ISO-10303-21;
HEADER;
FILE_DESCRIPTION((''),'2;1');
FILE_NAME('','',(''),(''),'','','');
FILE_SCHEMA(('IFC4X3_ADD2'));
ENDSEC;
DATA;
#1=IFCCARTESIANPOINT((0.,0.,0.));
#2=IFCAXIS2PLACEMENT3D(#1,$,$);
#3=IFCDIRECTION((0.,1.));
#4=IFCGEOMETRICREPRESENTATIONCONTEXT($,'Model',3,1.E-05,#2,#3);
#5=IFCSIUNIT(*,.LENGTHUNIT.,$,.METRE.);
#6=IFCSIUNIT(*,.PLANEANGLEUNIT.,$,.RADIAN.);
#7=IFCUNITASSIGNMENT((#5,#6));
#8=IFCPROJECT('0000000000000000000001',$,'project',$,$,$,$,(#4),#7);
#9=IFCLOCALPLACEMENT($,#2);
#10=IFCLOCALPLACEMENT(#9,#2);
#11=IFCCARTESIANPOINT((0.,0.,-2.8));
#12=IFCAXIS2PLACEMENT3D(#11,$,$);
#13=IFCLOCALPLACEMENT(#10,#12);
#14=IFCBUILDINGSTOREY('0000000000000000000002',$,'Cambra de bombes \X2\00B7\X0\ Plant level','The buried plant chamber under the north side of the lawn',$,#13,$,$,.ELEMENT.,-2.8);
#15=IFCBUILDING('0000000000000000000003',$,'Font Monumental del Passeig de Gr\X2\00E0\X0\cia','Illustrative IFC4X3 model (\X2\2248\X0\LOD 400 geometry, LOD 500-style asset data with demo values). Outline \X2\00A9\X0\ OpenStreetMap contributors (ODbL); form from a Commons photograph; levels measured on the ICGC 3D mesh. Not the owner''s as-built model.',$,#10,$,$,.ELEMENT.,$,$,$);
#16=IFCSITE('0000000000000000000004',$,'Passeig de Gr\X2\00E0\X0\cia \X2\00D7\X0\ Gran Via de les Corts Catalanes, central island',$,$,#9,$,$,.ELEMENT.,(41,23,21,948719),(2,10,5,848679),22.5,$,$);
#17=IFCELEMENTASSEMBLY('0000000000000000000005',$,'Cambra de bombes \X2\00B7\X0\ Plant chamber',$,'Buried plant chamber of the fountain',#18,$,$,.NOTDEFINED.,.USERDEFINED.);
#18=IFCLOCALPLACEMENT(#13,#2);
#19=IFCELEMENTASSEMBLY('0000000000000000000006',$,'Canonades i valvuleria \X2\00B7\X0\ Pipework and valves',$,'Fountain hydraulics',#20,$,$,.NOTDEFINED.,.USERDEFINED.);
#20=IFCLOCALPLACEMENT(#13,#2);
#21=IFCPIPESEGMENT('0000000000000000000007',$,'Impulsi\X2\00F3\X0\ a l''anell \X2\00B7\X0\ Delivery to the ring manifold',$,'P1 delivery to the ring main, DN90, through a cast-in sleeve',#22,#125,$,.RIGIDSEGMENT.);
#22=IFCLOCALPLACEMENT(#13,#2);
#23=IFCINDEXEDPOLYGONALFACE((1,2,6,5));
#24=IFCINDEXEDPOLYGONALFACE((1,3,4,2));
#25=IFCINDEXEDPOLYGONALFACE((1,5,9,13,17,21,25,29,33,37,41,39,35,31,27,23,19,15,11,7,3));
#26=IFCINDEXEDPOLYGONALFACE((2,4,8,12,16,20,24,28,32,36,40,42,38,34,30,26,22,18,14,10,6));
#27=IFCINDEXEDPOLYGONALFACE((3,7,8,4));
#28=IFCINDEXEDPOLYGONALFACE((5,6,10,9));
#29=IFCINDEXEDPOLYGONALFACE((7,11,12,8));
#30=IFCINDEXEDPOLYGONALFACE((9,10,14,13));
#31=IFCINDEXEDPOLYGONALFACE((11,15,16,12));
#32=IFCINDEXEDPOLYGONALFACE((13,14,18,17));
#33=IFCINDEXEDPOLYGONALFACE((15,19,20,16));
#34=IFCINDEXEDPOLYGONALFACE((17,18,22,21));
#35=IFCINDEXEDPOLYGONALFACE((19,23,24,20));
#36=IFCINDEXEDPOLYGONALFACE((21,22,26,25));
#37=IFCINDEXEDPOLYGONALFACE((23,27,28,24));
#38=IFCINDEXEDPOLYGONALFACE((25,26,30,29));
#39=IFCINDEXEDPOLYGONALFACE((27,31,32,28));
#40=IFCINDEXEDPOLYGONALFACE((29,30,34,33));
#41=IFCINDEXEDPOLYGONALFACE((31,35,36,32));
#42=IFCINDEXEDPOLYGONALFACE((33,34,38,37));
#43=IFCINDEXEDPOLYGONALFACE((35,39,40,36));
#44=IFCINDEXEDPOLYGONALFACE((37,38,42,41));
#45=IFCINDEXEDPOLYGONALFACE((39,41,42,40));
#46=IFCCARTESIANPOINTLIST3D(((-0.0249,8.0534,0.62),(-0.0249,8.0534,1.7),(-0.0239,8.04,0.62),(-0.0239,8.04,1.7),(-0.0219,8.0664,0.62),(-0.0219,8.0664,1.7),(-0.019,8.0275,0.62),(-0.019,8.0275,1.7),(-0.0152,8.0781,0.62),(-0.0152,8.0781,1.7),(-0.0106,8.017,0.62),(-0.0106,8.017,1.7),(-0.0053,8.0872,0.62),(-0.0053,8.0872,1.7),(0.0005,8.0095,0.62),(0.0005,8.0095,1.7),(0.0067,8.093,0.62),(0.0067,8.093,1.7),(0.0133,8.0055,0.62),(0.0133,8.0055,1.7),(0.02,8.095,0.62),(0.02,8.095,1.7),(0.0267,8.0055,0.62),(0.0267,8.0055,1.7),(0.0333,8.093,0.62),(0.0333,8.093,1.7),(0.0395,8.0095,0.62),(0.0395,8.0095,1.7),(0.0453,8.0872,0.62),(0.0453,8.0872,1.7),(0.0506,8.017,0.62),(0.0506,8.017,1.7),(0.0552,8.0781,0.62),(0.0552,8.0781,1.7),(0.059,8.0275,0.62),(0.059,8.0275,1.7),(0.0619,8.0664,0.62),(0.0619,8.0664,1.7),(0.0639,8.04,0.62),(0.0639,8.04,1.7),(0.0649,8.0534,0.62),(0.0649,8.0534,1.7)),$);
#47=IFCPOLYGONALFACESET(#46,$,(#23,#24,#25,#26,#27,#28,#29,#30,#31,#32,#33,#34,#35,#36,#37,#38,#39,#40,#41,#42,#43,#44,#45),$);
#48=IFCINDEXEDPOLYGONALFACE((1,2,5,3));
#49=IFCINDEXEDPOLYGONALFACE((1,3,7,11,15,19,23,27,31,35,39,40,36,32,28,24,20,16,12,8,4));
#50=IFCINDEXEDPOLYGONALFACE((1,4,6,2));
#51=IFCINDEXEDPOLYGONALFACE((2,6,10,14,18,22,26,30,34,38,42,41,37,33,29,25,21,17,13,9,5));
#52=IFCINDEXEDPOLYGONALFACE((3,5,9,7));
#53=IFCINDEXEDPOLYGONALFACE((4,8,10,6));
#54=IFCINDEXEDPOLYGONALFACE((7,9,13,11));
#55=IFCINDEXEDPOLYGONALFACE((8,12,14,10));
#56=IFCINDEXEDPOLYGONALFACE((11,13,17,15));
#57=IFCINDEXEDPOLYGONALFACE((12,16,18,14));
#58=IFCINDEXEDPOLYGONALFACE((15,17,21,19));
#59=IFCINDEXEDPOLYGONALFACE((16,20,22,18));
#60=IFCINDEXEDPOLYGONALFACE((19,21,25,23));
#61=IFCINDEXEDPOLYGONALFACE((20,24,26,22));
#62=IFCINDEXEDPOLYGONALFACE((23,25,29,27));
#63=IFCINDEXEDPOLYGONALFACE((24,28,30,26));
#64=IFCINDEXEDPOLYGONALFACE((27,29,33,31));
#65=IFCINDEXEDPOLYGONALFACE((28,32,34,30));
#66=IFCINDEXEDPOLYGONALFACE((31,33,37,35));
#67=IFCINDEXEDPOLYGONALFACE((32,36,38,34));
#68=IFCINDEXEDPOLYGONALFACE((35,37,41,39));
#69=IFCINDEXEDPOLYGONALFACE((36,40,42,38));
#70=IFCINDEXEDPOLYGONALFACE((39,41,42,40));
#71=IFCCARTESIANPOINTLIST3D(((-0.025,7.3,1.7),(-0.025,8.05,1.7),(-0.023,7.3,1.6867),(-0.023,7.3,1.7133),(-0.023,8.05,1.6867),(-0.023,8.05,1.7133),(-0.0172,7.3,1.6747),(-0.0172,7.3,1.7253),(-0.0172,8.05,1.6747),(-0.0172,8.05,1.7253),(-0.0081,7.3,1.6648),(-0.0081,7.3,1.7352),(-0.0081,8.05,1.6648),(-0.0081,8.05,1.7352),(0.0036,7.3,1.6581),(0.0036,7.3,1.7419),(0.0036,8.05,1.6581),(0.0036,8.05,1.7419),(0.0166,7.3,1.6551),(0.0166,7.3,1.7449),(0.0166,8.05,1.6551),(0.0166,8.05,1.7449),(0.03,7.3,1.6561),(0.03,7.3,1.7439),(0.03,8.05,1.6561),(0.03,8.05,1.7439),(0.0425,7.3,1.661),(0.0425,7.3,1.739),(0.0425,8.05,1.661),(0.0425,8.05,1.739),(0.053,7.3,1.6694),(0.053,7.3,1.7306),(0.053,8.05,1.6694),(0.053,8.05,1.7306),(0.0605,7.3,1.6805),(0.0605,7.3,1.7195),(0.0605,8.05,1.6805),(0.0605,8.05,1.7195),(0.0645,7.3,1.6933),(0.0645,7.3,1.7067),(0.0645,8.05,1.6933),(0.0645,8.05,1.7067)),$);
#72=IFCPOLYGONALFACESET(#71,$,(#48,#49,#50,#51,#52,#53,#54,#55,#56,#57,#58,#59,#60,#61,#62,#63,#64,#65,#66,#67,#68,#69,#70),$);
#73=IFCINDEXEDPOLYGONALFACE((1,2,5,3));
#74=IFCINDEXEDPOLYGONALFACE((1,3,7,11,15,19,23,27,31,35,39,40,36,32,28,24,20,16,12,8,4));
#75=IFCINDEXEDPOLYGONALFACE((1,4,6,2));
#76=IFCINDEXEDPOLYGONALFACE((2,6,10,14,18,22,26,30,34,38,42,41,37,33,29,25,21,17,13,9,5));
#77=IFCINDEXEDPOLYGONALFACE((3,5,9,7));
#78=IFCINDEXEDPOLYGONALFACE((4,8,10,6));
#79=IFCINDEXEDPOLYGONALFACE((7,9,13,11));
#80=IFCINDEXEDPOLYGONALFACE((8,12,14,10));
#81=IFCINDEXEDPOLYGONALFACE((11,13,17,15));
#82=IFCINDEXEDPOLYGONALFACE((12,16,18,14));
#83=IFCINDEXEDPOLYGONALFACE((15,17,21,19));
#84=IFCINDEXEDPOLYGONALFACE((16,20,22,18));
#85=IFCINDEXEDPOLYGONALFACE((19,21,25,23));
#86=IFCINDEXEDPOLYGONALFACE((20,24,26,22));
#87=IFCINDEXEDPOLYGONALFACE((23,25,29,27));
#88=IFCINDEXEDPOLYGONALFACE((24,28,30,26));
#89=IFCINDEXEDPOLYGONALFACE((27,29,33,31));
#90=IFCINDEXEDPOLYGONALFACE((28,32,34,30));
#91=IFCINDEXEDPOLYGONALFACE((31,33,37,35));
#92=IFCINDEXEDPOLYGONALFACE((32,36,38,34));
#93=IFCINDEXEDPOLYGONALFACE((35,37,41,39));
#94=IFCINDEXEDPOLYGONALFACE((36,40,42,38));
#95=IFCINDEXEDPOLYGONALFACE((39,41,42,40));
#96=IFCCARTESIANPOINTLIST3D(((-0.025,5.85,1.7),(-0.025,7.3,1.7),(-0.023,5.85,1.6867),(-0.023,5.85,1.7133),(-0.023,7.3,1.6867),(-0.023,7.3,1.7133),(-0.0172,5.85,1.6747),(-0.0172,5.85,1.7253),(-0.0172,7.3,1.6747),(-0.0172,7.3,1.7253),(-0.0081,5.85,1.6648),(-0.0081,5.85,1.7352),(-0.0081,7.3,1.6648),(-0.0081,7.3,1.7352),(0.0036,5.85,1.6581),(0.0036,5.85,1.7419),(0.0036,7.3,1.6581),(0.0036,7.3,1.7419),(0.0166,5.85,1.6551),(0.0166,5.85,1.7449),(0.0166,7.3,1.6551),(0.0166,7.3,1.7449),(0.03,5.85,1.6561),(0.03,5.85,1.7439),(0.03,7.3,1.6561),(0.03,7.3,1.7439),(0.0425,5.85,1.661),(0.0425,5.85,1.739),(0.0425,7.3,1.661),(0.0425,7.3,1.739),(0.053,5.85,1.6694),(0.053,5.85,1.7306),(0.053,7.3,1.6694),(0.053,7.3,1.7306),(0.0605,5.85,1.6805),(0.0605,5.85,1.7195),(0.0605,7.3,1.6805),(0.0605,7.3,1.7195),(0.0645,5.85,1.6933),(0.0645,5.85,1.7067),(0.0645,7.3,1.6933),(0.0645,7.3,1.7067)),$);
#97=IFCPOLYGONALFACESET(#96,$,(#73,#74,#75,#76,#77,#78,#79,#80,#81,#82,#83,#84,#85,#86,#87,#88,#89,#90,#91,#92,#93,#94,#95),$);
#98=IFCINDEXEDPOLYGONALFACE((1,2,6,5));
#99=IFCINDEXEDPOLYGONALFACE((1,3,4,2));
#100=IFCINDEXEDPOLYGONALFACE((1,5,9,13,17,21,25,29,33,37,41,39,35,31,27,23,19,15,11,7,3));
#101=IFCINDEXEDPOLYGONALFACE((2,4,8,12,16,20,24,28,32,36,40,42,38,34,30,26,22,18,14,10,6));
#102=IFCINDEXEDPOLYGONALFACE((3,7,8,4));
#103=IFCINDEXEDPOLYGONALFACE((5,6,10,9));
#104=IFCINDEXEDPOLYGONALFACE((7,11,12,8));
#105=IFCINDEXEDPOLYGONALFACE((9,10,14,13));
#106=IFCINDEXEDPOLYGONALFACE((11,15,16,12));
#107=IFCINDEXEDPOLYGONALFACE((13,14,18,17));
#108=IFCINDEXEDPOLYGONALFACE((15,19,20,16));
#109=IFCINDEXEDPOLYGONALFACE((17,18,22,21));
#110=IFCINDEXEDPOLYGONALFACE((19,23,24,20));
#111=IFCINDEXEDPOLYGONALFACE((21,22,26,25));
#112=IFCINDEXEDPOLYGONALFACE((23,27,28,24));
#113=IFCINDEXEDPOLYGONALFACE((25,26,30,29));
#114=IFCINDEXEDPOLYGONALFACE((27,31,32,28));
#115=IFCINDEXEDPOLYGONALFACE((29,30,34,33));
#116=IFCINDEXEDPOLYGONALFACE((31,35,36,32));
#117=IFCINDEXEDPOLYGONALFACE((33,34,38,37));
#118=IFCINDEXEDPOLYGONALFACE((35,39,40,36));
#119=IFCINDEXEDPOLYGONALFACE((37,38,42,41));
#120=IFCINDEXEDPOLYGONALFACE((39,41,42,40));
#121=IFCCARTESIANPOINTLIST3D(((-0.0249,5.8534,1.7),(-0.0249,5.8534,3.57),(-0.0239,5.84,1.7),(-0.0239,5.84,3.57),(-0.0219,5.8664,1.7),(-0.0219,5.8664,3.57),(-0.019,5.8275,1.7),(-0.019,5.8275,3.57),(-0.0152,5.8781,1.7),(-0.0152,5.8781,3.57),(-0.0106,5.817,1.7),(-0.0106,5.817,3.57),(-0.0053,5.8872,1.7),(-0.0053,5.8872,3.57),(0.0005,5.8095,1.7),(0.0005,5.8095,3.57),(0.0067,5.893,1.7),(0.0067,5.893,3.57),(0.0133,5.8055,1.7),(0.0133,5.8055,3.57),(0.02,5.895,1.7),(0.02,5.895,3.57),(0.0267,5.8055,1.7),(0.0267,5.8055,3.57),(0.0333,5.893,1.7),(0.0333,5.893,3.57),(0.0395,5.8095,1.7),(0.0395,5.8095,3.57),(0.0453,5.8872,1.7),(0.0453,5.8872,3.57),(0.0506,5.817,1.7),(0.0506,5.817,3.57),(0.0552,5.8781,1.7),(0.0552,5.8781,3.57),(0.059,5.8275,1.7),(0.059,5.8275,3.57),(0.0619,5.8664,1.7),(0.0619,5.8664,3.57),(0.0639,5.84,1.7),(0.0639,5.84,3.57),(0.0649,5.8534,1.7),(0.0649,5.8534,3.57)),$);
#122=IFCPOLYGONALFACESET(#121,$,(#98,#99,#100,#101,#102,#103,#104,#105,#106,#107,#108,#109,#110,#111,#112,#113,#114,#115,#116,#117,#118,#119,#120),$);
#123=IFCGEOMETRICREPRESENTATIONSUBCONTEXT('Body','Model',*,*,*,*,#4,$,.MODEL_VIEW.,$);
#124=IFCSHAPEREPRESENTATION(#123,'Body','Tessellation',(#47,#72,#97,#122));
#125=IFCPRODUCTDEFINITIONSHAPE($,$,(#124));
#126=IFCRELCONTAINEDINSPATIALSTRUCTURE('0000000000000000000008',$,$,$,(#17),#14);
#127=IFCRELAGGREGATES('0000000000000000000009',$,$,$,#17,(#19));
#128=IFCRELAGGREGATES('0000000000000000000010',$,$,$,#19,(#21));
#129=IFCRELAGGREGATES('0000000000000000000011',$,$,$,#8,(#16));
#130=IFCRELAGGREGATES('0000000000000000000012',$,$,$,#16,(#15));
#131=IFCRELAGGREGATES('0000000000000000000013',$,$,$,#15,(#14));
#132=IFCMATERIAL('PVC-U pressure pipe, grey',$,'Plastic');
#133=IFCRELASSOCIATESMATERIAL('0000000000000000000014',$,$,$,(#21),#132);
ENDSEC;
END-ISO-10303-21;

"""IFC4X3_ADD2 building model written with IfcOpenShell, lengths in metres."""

from ifc_helpers import new_model, si_unit, direction, frame, origin, origin_2d_with_axis, place, context, subcontext, project, spatial, circle, extrude, material, element, aggregate, save


model = new_model("IFC4X3_ADD2")

# Units and contexts
model_context = context("Model", 3, precision=1e-05, world=origin(), true_north=direction((0.0, 1.0)))
body_context = subcontext(model_context, "Body", "Model", "MODEL_VIEW")
ifc_project = project(units=[si_unit("LENGTHUNIT", "METRE"), si_unit("PLANEANGLEUNIT", "RADIAN")], contexts=[model_context])

# Site, building, storey
site_placement = place(None, origin())
site = spatial("IfcSite", under=ifc_project, at=site_placement, Name="Passeig de Gràcia × Gran Via de les Corts Catalanes, central island", CompositionType="ELEMENT", RefLatitude=(41, 23, 21, 948719), RefLongitude=(2, 10, 5, 848679), RefElevation=22.5)
building_placement = place(site_placement, origin())
building = spatial("IfcBuilding", under=site, at=building_placement, Name="Font Monumental del Passeig de Gràcia", Description="Illustrative IFC4X3 model (≈LOD 400 geometry, LOD 500-style asset data with demo values). Outline © OpenStreetMap contributors (ODbL); form from a Commons photograph; levels measured on the ICGC 3D mesh. Not the owner's as-built model.", CompositionType="ELEMENT")
storey_placement = place(building_placement, frame((0.0, 0.0, -2.8)))
storey = spatial("IfcBuildingStorey", under=building, at=storey_placement, Name="Cambra de bombes · Plant level", Description="The buried plant chamber under the north side of the lawn", CompositionType="ELEMENT", Elevation=-2.8)

# Element assemblies, pipe segment
assembly_1_placement = place(building_placement, origin())
assembly_1 = element("IfcElementAssembly", 1, at=assembly_1_placement, inside=storey, Name="Cambra de bombes · Plant chamber", ObjectType="Buried plant chamber of the fountain", AssemblyPlace="NOTDEFINED", PredefinedType="USERDEFINED")
assembly_2_placement = place(building_placement, origin())
assembly_2 = element("IfcElementAssembly", 2, at=assembly_2_placement, Name="Canonades i valvuleria · Pipework and valves", ObjectType="Fountain hydraulics", AssemblyPlace="NOTDEFINED", PredefinedType="USERDEFINED")
aggregate(assembly_1, [assembly_2])
ifc_material_1 = material(Name="PVC-U pressure pipe, grey", Category="Plastic")
pipe_segment_1_placement = place(building_placement, origin())
pipe_segment_1 = element("IfcPipeSegment", 3, at=pipe_segment_1_placement, material=ifc_material_1, Name="Impulsió a l'anell · Delivery to the ring manifold", ObjectType="P1 delivery to the ring main, DN90, through a cast-in sleeve", PredefinedType="RIGIDSEGMENT", context=body_context, shape_type="SweptSolid", body=[
    extrude(circle(Radius=0.045, at=origin_2d_with_axis()), frame((0.02, 8.05, -2.18), z_axis=(0.0, 0.0, 1.0), x_axis=(0.0, 1.0, 0.0)), (0.0, 0.0, 1.0), 1.08),
    extrude(circle(Radius=0.045, at=origin_2d_with_axis()), frame((0.02, 8.05, -1.1), z_axis=(0.0, -1.0, 0.0), x_axis=(-1.0, 0.0, 0.0)), (0.0, 0.0, 1.0), 0.75),
    extrude(circle(Radius=0.045, at=origin_2d_with_axis()), frame((0.02, 7.3, -1.1), z_axis=(0.0, -1.0, 0.0), x_axis=(-1.0, 0.0, 0.0)), (0.0, 0.0, 1.0), 1.45),
    extrude(circle(Radius=0.045, at=origin_2d_with_axis()), frame((0.02, 5.85, -1.1), z_axis=(0.0, 0.0, 1.0), x_axis=(0.0, 1.0, 0.0)), (0.0, 0.0, 1.0), 1.87),
])
aggregate(assembly_2, [pipe_segment_1])

save(model, "model.ifc")
